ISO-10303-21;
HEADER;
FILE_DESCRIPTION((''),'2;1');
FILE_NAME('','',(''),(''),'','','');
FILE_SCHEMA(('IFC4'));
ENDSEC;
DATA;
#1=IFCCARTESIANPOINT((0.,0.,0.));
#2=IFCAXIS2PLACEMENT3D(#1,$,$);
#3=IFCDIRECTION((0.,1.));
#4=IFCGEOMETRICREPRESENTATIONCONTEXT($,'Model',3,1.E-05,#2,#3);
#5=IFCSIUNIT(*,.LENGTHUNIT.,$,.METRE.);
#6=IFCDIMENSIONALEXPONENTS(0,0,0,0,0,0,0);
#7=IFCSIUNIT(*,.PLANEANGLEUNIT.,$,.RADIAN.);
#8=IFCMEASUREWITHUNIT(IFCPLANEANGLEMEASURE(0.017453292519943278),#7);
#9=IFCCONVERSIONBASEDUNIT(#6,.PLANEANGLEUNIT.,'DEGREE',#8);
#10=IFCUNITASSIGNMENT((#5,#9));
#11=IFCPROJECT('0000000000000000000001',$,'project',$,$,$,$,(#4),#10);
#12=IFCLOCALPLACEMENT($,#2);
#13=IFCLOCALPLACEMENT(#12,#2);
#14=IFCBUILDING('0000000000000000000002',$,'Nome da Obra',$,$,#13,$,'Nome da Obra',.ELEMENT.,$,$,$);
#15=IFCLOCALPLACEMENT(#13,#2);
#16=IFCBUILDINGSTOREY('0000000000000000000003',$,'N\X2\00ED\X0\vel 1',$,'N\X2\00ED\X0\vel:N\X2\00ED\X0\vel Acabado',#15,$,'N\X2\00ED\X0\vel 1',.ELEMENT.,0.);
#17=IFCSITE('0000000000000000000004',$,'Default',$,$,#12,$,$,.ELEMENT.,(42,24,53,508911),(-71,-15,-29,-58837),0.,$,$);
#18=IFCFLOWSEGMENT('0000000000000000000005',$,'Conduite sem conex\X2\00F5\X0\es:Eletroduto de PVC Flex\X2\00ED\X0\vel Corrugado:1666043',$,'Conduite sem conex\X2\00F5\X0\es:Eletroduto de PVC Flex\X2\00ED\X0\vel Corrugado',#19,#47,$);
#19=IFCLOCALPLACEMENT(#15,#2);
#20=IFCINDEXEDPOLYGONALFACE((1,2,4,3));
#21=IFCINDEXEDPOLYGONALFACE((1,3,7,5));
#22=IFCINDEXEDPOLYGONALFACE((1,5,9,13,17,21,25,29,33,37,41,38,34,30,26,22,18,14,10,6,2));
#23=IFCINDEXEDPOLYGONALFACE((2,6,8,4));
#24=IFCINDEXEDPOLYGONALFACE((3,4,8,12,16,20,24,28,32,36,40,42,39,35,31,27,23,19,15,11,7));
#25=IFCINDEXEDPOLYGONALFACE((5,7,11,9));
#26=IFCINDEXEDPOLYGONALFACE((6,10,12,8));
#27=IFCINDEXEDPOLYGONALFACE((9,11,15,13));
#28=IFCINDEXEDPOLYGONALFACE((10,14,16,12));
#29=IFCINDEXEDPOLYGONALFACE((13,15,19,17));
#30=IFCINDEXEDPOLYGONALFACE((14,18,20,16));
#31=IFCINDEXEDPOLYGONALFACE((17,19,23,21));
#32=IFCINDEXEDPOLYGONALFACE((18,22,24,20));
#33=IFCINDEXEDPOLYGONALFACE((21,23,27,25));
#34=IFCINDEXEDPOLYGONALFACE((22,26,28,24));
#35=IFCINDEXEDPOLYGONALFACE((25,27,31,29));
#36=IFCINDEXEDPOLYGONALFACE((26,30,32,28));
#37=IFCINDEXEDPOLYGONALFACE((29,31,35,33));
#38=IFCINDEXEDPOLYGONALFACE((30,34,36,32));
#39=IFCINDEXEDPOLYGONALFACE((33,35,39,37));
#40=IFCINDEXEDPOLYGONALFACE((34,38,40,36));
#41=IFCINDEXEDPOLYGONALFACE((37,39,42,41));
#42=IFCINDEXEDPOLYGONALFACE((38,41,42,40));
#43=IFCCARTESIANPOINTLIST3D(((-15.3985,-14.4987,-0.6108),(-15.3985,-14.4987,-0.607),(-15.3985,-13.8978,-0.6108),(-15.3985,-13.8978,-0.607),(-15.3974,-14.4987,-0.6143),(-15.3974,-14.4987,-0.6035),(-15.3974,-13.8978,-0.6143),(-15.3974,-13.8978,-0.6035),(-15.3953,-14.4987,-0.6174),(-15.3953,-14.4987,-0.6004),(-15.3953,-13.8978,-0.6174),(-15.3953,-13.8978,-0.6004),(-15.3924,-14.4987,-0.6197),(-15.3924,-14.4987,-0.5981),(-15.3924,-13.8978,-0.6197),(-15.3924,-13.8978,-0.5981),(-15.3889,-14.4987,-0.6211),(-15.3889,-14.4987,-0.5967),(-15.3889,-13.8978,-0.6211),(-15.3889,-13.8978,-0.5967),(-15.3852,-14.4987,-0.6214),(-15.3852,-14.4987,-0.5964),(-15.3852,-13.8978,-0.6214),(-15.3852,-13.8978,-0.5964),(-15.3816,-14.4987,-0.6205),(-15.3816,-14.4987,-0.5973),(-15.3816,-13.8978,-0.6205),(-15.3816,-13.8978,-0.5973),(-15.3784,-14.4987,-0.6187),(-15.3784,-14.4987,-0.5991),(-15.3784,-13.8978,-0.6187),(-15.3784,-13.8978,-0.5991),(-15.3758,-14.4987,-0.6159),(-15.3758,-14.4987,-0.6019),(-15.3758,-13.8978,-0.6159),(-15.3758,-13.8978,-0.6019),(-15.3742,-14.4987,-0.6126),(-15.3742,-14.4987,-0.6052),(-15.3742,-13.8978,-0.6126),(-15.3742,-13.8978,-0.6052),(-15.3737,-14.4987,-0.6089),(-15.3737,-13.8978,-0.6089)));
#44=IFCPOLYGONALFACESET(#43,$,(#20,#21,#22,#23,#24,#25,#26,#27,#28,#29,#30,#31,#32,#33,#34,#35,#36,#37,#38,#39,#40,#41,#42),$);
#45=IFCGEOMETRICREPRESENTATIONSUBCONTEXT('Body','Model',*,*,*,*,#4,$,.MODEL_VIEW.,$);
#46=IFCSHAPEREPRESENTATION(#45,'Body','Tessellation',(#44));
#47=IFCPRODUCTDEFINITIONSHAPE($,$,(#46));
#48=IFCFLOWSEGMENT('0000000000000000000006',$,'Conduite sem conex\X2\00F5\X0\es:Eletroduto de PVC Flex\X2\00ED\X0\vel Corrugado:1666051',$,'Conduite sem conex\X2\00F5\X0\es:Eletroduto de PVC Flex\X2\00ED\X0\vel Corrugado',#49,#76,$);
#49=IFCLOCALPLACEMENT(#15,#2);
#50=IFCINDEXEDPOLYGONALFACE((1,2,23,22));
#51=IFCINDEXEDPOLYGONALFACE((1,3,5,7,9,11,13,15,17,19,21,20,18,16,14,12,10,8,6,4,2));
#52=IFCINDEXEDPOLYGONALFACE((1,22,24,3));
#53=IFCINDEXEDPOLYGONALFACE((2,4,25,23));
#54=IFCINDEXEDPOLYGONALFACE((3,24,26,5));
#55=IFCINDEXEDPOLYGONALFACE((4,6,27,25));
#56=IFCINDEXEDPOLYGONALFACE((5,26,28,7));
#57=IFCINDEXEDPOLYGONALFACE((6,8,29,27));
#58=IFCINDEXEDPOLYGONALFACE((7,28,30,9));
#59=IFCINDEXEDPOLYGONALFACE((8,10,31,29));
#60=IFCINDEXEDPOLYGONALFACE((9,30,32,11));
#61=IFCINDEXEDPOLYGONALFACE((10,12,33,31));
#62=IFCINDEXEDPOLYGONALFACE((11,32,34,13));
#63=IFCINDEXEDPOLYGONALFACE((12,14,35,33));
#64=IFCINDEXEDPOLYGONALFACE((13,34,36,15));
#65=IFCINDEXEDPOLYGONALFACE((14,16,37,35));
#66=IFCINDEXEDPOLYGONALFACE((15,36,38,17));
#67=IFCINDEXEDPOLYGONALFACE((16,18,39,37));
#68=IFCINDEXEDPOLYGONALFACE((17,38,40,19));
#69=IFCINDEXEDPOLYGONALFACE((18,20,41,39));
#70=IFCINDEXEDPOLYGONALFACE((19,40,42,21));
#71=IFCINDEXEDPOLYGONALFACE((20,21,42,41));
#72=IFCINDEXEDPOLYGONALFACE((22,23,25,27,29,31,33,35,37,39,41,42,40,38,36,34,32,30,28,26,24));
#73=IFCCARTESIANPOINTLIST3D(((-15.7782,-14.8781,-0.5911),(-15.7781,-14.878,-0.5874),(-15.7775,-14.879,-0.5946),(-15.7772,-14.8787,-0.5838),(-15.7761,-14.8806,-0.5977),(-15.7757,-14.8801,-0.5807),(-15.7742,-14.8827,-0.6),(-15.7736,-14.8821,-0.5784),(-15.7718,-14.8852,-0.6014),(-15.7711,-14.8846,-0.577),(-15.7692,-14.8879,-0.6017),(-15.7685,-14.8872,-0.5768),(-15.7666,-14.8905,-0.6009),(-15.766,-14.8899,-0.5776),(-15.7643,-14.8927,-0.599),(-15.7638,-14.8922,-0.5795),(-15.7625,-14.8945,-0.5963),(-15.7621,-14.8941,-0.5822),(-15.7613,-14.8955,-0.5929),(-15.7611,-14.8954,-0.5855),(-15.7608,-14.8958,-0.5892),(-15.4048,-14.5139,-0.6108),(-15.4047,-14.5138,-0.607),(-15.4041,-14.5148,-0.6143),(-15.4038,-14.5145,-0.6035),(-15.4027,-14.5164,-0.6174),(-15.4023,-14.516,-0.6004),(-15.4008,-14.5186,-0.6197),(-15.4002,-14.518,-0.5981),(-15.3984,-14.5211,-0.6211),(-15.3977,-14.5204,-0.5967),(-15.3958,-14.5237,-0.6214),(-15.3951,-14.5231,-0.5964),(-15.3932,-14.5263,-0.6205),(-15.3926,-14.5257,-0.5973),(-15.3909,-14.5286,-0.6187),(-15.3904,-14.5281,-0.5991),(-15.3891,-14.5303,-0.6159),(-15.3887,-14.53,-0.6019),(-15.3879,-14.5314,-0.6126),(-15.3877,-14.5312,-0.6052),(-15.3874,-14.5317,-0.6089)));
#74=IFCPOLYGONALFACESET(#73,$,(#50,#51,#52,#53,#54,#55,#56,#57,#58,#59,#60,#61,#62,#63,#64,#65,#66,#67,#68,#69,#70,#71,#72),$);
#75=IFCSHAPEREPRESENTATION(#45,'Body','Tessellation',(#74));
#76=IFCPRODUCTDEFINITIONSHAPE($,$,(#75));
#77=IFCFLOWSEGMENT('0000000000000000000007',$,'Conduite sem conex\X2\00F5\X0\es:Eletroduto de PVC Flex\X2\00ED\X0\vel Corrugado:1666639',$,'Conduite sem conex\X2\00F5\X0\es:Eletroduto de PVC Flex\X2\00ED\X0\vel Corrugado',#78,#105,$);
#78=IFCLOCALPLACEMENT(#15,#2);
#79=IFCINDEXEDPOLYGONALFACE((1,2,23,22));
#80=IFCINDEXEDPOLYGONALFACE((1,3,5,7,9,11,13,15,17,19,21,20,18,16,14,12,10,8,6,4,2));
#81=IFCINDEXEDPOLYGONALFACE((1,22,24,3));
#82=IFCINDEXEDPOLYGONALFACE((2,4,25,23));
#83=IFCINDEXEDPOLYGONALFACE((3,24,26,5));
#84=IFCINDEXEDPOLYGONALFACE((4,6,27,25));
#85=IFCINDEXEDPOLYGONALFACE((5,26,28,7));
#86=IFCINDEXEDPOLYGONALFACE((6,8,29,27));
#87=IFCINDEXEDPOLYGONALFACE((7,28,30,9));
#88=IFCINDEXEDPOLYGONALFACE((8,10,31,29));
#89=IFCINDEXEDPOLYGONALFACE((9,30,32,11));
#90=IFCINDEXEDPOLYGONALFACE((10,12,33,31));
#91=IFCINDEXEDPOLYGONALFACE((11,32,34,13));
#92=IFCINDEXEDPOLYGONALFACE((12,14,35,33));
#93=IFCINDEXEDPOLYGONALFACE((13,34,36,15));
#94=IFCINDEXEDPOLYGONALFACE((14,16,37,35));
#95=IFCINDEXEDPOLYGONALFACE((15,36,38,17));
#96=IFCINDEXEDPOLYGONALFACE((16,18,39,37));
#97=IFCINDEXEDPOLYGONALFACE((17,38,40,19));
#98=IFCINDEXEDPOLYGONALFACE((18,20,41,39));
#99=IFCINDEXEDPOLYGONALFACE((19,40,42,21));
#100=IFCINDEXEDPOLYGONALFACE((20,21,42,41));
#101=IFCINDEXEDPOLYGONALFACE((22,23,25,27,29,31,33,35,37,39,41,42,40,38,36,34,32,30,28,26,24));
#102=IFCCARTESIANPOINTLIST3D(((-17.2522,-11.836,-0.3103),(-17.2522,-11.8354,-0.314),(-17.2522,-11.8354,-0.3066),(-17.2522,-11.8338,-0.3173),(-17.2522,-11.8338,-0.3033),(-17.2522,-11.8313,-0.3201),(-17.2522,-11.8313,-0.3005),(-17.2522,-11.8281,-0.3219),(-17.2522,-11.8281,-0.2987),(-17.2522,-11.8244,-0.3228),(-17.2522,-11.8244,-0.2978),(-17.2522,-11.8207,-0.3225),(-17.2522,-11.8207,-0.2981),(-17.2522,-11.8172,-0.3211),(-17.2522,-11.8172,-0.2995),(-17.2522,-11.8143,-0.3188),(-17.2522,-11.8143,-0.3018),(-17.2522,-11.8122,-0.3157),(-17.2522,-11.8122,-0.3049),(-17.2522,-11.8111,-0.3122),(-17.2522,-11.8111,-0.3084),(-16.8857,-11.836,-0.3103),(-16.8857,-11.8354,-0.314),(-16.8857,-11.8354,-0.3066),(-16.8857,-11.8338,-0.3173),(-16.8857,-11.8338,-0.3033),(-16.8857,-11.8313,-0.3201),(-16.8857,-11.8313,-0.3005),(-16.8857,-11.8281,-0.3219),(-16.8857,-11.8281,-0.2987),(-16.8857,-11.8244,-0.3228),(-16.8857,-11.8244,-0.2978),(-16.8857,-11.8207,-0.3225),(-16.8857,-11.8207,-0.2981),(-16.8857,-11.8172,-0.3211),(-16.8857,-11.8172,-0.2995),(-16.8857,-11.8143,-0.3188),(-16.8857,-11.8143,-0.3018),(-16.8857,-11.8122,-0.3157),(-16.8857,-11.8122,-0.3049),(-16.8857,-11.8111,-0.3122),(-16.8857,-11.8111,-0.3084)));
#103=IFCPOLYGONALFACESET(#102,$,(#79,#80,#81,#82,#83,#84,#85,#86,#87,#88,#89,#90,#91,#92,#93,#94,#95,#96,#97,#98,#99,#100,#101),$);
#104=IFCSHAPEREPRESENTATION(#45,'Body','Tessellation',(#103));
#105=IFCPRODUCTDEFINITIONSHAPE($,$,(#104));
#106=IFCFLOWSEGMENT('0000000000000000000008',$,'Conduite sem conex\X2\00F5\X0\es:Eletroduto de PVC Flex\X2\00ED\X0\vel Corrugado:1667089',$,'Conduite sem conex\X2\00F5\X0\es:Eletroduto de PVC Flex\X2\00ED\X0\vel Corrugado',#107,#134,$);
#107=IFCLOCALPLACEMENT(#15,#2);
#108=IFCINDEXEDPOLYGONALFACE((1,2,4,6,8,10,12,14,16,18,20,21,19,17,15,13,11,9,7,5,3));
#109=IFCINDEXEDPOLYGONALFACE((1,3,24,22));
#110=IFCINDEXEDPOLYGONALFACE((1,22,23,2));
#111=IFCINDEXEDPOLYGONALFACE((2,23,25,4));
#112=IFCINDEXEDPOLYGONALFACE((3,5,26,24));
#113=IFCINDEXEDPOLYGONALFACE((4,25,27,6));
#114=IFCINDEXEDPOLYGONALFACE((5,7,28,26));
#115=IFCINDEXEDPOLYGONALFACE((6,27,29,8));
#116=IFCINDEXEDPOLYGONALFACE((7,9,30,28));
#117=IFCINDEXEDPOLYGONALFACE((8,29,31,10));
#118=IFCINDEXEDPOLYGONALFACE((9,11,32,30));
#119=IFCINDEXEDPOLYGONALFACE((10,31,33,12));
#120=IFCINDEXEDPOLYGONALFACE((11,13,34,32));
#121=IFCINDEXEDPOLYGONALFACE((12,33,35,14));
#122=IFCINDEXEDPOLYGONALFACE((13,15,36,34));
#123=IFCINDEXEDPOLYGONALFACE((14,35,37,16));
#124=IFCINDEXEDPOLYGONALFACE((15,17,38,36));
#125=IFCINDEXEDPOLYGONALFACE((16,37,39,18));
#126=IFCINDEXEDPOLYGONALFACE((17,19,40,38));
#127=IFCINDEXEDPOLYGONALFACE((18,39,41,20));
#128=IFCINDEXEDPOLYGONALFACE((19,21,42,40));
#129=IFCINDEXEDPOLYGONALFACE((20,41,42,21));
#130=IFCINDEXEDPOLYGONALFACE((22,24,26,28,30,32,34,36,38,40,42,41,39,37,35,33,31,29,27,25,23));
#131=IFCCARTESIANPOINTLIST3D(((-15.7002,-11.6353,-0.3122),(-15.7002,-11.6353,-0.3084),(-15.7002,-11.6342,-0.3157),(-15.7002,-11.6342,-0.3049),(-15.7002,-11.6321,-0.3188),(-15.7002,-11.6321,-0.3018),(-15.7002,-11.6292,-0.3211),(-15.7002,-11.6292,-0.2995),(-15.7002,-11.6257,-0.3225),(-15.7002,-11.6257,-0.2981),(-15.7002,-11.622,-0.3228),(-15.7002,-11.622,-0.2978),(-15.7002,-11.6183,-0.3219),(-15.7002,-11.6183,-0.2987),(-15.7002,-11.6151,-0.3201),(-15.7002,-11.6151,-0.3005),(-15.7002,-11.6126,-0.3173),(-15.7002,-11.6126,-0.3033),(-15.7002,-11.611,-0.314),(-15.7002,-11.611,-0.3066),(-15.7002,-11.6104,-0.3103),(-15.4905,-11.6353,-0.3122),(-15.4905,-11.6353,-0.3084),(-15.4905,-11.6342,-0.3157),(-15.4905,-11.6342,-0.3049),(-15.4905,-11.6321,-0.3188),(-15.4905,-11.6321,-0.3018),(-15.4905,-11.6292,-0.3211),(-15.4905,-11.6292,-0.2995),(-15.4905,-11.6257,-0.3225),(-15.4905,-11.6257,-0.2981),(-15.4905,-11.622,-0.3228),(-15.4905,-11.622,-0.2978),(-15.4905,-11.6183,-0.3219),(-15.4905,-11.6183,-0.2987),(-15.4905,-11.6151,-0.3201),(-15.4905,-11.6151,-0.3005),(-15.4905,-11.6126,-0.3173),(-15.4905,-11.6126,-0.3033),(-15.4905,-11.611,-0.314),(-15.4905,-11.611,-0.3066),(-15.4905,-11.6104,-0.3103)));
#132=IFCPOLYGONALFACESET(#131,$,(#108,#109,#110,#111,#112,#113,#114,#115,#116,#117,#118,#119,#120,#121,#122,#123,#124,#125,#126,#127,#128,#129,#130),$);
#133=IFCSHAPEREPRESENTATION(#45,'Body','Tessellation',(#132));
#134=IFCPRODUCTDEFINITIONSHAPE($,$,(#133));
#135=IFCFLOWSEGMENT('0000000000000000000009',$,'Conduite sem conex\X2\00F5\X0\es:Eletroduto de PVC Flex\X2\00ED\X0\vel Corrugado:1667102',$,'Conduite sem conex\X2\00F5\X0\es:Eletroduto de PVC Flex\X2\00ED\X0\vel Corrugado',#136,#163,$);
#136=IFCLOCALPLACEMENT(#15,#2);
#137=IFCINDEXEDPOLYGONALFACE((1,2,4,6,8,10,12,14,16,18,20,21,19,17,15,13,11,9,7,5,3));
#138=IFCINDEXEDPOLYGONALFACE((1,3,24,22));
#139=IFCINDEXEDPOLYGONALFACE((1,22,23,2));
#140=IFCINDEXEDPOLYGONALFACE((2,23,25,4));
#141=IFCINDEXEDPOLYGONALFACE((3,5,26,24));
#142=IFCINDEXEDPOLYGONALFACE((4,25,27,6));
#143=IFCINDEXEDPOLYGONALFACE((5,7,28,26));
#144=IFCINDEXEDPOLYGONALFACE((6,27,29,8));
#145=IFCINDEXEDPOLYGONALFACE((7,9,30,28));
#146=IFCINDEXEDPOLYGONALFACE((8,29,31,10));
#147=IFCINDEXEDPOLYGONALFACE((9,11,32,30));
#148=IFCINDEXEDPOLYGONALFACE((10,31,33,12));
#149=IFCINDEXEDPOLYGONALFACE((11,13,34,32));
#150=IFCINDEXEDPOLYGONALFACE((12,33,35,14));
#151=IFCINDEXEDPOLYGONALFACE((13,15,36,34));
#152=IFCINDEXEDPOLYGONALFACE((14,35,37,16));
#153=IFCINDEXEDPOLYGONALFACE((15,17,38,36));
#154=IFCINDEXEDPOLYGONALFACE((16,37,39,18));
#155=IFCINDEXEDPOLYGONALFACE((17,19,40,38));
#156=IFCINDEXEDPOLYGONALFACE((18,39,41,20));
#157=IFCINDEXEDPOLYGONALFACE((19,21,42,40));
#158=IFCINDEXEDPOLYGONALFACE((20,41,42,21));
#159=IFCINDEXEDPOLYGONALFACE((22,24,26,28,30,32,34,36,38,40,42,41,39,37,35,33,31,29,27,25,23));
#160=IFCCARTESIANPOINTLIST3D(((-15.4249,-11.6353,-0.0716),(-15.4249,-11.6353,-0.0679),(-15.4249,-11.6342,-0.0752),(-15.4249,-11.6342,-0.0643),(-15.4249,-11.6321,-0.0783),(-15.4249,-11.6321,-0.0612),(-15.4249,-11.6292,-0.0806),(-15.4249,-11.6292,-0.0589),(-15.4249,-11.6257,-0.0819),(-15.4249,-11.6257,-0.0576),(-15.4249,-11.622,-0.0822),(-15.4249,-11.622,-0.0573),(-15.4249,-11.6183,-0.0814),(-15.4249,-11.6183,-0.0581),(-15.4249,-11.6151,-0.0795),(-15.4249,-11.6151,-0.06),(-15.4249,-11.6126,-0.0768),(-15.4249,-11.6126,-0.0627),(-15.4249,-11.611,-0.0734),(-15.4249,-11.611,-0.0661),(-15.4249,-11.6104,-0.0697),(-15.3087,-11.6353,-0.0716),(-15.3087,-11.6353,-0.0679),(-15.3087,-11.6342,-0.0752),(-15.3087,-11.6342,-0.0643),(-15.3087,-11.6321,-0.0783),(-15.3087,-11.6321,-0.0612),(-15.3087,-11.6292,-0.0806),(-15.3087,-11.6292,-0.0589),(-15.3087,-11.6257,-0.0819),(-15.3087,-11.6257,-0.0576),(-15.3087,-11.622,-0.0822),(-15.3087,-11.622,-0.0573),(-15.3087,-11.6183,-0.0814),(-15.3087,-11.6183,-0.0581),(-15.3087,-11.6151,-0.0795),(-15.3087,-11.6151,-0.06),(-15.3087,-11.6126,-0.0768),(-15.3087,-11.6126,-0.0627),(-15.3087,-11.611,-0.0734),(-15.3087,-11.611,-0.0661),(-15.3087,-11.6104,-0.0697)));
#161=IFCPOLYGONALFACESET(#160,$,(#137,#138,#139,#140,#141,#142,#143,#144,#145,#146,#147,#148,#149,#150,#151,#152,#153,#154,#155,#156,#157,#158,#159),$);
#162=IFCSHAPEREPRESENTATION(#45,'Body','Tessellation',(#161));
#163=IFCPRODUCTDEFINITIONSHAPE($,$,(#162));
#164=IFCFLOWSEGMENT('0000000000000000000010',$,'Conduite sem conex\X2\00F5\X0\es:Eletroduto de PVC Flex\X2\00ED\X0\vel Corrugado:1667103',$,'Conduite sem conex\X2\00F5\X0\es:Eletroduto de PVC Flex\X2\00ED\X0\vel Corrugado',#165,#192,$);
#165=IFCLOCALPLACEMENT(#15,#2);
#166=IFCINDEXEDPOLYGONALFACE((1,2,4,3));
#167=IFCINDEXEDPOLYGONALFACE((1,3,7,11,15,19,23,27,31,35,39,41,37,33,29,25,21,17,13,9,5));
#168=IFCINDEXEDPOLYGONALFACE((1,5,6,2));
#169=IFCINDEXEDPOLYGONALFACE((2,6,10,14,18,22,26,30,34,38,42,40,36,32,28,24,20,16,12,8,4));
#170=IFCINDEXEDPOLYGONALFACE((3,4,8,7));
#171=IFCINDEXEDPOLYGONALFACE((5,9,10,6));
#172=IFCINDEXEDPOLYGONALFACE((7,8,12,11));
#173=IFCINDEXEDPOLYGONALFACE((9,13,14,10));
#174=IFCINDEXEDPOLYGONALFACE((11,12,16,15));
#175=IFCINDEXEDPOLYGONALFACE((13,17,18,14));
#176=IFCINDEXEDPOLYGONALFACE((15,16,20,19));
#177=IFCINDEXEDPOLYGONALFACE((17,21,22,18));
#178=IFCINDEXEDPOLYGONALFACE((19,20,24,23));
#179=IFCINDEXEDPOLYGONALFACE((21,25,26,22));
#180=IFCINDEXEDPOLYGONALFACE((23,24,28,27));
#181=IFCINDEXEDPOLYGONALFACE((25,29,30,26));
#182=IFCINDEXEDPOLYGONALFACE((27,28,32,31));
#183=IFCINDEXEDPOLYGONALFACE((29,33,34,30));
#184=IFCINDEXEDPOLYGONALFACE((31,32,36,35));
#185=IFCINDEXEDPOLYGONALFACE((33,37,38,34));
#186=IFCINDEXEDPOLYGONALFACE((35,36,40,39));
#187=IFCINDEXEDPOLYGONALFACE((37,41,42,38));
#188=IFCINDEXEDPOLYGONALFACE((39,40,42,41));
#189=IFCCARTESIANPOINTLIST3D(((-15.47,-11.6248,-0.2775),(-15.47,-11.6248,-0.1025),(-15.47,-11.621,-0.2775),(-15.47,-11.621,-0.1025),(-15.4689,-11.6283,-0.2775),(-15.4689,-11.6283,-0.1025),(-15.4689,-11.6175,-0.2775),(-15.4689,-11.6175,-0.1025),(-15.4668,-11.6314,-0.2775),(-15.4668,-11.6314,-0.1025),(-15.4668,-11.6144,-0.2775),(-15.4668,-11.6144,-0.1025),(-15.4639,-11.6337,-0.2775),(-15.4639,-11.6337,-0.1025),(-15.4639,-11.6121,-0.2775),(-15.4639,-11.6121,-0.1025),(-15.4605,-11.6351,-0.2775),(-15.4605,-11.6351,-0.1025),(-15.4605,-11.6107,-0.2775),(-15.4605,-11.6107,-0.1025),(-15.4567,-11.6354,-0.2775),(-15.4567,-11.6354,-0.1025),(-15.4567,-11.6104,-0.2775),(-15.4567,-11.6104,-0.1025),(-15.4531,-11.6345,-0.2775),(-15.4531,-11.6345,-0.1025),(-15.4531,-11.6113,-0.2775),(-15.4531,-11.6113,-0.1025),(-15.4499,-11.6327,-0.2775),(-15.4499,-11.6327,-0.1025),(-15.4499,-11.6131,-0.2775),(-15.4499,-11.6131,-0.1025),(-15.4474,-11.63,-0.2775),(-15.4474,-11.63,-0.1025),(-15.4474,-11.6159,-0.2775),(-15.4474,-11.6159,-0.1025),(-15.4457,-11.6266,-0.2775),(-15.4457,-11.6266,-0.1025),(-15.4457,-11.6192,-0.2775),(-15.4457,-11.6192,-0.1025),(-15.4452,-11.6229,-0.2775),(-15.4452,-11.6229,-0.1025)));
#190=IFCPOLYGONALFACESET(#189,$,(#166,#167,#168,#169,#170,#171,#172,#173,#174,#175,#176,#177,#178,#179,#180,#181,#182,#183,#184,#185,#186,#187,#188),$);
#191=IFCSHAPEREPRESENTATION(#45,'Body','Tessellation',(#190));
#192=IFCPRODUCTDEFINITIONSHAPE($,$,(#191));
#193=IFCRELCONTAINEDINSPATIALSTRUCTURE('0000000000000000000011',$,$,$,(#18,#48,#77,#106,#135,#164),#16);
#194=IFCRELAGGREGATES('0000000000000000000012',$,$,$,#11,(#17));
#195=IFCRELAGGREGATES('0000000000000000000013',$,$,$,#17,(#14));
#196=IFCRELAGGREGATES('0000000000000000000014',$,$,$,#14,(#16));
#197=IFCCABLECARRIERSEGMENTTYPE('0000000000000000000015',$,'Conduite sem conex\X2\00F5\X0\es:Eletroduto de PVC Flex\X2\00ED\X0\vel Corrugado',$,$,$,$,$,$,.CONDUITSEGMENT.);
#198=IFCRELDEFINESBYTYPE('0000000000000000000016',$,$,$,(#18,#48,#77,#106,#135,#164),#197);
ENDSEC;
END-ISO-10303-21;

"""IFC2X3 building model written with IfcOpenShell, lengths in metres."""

from ifc_helpers import new_model, entity, si_unit, converted_unit, direction, frame, frame_2d, origin, origin_2d_with_axis, place, context, subcontext, project, spatial, circle, extrude, type_object, element, save


model = new_model("IFC2X3")

# Units and contexts
model_context = context("Model", 3, precision=1e-05, world=origin(), true_north=direction((0.0, 1.0)))
body_context = subcontext(model_context, "Body", "Model", "MODEL_VIEW")
ifc_project = project(units=[si_unit("LENGTHUNIT", "METRE"), converted_unit("PLANEANGLEUNIT", "DEGREE", entity("IfcPlaneAngleMeasure", 0.017453292519943278), si_unit("PLANEANGLEUNIT", "RADIAN"), dimensions=[0, 0, 0, 0, 0, 0, 0])], contexts=[model_context])

# Site, building, storey
site_placement = place(None, origin())
site = spatial("IfcSite", under=ifc_project, at=site_placement, Name="Default", CompositionType="ELEMENT", RefLatitude=(42, 24, 53, 508911), RefLongitude=(-71, -15, -29, -58837), RefElevation=0.0)
building_placement = place(site_placement, origin())
building = spatial("IfcBuilding", under=site, at=building_placement, Name="Nome da Obra", LongName="Nome da Obra", CompositionType="ELEMENT")
storey_placement = place(building_placement, origin())
storey = spatial("IfcBuildingStorey", under=building, at=storey_placement, Name="Nível 1", ObjectType="Nível:Nível Acabado", LongName="Nível 1", CompositionType="ELEMENT", Elevation=0.0)

# Flow segments
cable_carrier_segment_type = type_object("IfcCableCarrierSegmentType", Name="Conduite sem conexões:Eletroduto de PVC Flexível Corrugado", PredefinedType="CONDUITSEGMENT")
flow_segment_1_placement = place(storey_placement, origin())
element("IfcFlowSegment", 1, at=flow_segment_1_placement, inside=storey, type_object=cable_carrier_segment_type, Name="Conduite sem conexões:Eletroduto de PVC Flexível Corrugado:1666043", ObjectType="Conduite sem conexões:Eletroduto de PVC Flexível Corrugado", context=body_context, shape_type="SweptSolid", body=[
    extrude(circle(Radius=0.0125, at=frame_2d((0.0, 0.0), x_axis=(1.0, 0.0))), frame((-15.3862, -14.4987, -0.6089), z_axis=(0.0, 1.0, 0.0), x_axis=(1.0, 0.0, 0.0)), (0.0, 0.0, 1.0), 0.601),
])
flow_segment_2_placement = place(storey_placement, origin())
element("IfcFlowSegment", 2, at=flow_segment_2_placement, inside=storey, type_object=cable_carrier_segment_type, Name="Conduite sem conexões:Eletroduto de PVC Flexível Corrugado:1666051", ObjectType="Conduite sem conexões:Eletroduto de PVC Flexível Corrugado", context=body_context, shape_type="SweptSolid", body=[
    extrude(circle(Radius=0.0125, at=frame_2d((0.0, 0.0), x_axis=(1.0, 0.0))), frame((-15.7695, -14.8869, -0.5892), z_axis=(0.71542, 0.697677, -0.037697), x_axis=(0.698174, -0.715928, 0.0)), (0.0, 0.0, 1.0), 0.522),
])
flow_segment_3_placement = place(storey_placement, origin())
element("IfcFlowSegment", 3, at=flow_segment_3_placement, inside=storey, type_object=cable_carrier_segment_type, Name="Conduite sem conexões:Eletroduto de PVC Flexível Corrugado:1666639", ObjectType="Conduite sem conexões:Eletroduto de PVC Flexível Corrugado", context=body_context, shape_type="SweptSolid", body=[
    extrude(circle(Radius=0.0125, at=origin_2d_with_axis()), frame((-17.2522, -11.8235, -0.3103), z_axis=(1.0, 0.0, 0.0), x_axis=(0.0, -1.0, 0.0)), (0.0, 0.0, 1.0), 0.3665),
])
flow_segment_4_placement = place(storey_placement, origin())
element("IfcFlowSegment", 4, at=flow_segment_4_placement, inside=storey, type_object=cable_carrier_segment_type, Name="Conduite sem conexões:Eletroduto de PVC Flexível Corrugado:1667089", ObjectType="Conduite sem conexões:Eletroduto de PVC Flexível Corrugado", context=body_context, shape_type="SweptSolid", body=[
    extrude(circle(Radius=0.0125, at=frame_2d((0.0, 0.0), x_axis=(1.0, 0.0))), frame((-15.7002, -11.6229, -0.3103), z_axis=(1.0, 0.0, 0.0), x_axis=(0.0, 1.0, 0.0)), (0.0, 0.0, 1.0), 0.2097),
])
flow_segment_5_placement = place(storey_placement, origin())
element("IfcFlowSegment", 5, at=flow_segment_5_placement, inside=storey, type_object=cable_carrier_segment_type, Name="Conduite sem conexões:Eletroduto de PVC Flexível Corrugado:1667102", ObjectType="Conduite sem conexões:Eletroduto de PVC Flexível Corrugado", context=body_context, shape_type="SweptSolid", body=[
    extrude(circle(Radius=0.0125, at=frame_2d((0.0, 0.0), x_axis=(1.0, 0.0))), frame((-15.4249, -11.6229, -0.0697), z_axis=(1.0, 0.0, 0.0), x_axis=(0.0, 1.0, 0.0)), (0.0, 0.0, 1.0), 0.1162),
])
flow_segment_6_placement = place(storey_placement, origin())
element("IfcFlowSegment", 6, at=flow_segment_6_placement, inside=storey, type_object=cable_carrier_segment_type, Name="Conduite sem conexões:Eletroduto de PVC Flexível Corrugado:1667103", ObjectType="Conduite sem conexões:Eletroduto de PVC Flexível Corrugado", context=body_context, shape_type="SweptSolid", body=[
    extrude(circle(Radius=0.0125, at=frame_2d((0.0, 0.0), x_axis=(1.0, 0.0))), frame((-15.4577, -11.6229, -0.2775)), (0.0, 0.0, 1.0), 0.175),
])

save(model, "model.ifc")
